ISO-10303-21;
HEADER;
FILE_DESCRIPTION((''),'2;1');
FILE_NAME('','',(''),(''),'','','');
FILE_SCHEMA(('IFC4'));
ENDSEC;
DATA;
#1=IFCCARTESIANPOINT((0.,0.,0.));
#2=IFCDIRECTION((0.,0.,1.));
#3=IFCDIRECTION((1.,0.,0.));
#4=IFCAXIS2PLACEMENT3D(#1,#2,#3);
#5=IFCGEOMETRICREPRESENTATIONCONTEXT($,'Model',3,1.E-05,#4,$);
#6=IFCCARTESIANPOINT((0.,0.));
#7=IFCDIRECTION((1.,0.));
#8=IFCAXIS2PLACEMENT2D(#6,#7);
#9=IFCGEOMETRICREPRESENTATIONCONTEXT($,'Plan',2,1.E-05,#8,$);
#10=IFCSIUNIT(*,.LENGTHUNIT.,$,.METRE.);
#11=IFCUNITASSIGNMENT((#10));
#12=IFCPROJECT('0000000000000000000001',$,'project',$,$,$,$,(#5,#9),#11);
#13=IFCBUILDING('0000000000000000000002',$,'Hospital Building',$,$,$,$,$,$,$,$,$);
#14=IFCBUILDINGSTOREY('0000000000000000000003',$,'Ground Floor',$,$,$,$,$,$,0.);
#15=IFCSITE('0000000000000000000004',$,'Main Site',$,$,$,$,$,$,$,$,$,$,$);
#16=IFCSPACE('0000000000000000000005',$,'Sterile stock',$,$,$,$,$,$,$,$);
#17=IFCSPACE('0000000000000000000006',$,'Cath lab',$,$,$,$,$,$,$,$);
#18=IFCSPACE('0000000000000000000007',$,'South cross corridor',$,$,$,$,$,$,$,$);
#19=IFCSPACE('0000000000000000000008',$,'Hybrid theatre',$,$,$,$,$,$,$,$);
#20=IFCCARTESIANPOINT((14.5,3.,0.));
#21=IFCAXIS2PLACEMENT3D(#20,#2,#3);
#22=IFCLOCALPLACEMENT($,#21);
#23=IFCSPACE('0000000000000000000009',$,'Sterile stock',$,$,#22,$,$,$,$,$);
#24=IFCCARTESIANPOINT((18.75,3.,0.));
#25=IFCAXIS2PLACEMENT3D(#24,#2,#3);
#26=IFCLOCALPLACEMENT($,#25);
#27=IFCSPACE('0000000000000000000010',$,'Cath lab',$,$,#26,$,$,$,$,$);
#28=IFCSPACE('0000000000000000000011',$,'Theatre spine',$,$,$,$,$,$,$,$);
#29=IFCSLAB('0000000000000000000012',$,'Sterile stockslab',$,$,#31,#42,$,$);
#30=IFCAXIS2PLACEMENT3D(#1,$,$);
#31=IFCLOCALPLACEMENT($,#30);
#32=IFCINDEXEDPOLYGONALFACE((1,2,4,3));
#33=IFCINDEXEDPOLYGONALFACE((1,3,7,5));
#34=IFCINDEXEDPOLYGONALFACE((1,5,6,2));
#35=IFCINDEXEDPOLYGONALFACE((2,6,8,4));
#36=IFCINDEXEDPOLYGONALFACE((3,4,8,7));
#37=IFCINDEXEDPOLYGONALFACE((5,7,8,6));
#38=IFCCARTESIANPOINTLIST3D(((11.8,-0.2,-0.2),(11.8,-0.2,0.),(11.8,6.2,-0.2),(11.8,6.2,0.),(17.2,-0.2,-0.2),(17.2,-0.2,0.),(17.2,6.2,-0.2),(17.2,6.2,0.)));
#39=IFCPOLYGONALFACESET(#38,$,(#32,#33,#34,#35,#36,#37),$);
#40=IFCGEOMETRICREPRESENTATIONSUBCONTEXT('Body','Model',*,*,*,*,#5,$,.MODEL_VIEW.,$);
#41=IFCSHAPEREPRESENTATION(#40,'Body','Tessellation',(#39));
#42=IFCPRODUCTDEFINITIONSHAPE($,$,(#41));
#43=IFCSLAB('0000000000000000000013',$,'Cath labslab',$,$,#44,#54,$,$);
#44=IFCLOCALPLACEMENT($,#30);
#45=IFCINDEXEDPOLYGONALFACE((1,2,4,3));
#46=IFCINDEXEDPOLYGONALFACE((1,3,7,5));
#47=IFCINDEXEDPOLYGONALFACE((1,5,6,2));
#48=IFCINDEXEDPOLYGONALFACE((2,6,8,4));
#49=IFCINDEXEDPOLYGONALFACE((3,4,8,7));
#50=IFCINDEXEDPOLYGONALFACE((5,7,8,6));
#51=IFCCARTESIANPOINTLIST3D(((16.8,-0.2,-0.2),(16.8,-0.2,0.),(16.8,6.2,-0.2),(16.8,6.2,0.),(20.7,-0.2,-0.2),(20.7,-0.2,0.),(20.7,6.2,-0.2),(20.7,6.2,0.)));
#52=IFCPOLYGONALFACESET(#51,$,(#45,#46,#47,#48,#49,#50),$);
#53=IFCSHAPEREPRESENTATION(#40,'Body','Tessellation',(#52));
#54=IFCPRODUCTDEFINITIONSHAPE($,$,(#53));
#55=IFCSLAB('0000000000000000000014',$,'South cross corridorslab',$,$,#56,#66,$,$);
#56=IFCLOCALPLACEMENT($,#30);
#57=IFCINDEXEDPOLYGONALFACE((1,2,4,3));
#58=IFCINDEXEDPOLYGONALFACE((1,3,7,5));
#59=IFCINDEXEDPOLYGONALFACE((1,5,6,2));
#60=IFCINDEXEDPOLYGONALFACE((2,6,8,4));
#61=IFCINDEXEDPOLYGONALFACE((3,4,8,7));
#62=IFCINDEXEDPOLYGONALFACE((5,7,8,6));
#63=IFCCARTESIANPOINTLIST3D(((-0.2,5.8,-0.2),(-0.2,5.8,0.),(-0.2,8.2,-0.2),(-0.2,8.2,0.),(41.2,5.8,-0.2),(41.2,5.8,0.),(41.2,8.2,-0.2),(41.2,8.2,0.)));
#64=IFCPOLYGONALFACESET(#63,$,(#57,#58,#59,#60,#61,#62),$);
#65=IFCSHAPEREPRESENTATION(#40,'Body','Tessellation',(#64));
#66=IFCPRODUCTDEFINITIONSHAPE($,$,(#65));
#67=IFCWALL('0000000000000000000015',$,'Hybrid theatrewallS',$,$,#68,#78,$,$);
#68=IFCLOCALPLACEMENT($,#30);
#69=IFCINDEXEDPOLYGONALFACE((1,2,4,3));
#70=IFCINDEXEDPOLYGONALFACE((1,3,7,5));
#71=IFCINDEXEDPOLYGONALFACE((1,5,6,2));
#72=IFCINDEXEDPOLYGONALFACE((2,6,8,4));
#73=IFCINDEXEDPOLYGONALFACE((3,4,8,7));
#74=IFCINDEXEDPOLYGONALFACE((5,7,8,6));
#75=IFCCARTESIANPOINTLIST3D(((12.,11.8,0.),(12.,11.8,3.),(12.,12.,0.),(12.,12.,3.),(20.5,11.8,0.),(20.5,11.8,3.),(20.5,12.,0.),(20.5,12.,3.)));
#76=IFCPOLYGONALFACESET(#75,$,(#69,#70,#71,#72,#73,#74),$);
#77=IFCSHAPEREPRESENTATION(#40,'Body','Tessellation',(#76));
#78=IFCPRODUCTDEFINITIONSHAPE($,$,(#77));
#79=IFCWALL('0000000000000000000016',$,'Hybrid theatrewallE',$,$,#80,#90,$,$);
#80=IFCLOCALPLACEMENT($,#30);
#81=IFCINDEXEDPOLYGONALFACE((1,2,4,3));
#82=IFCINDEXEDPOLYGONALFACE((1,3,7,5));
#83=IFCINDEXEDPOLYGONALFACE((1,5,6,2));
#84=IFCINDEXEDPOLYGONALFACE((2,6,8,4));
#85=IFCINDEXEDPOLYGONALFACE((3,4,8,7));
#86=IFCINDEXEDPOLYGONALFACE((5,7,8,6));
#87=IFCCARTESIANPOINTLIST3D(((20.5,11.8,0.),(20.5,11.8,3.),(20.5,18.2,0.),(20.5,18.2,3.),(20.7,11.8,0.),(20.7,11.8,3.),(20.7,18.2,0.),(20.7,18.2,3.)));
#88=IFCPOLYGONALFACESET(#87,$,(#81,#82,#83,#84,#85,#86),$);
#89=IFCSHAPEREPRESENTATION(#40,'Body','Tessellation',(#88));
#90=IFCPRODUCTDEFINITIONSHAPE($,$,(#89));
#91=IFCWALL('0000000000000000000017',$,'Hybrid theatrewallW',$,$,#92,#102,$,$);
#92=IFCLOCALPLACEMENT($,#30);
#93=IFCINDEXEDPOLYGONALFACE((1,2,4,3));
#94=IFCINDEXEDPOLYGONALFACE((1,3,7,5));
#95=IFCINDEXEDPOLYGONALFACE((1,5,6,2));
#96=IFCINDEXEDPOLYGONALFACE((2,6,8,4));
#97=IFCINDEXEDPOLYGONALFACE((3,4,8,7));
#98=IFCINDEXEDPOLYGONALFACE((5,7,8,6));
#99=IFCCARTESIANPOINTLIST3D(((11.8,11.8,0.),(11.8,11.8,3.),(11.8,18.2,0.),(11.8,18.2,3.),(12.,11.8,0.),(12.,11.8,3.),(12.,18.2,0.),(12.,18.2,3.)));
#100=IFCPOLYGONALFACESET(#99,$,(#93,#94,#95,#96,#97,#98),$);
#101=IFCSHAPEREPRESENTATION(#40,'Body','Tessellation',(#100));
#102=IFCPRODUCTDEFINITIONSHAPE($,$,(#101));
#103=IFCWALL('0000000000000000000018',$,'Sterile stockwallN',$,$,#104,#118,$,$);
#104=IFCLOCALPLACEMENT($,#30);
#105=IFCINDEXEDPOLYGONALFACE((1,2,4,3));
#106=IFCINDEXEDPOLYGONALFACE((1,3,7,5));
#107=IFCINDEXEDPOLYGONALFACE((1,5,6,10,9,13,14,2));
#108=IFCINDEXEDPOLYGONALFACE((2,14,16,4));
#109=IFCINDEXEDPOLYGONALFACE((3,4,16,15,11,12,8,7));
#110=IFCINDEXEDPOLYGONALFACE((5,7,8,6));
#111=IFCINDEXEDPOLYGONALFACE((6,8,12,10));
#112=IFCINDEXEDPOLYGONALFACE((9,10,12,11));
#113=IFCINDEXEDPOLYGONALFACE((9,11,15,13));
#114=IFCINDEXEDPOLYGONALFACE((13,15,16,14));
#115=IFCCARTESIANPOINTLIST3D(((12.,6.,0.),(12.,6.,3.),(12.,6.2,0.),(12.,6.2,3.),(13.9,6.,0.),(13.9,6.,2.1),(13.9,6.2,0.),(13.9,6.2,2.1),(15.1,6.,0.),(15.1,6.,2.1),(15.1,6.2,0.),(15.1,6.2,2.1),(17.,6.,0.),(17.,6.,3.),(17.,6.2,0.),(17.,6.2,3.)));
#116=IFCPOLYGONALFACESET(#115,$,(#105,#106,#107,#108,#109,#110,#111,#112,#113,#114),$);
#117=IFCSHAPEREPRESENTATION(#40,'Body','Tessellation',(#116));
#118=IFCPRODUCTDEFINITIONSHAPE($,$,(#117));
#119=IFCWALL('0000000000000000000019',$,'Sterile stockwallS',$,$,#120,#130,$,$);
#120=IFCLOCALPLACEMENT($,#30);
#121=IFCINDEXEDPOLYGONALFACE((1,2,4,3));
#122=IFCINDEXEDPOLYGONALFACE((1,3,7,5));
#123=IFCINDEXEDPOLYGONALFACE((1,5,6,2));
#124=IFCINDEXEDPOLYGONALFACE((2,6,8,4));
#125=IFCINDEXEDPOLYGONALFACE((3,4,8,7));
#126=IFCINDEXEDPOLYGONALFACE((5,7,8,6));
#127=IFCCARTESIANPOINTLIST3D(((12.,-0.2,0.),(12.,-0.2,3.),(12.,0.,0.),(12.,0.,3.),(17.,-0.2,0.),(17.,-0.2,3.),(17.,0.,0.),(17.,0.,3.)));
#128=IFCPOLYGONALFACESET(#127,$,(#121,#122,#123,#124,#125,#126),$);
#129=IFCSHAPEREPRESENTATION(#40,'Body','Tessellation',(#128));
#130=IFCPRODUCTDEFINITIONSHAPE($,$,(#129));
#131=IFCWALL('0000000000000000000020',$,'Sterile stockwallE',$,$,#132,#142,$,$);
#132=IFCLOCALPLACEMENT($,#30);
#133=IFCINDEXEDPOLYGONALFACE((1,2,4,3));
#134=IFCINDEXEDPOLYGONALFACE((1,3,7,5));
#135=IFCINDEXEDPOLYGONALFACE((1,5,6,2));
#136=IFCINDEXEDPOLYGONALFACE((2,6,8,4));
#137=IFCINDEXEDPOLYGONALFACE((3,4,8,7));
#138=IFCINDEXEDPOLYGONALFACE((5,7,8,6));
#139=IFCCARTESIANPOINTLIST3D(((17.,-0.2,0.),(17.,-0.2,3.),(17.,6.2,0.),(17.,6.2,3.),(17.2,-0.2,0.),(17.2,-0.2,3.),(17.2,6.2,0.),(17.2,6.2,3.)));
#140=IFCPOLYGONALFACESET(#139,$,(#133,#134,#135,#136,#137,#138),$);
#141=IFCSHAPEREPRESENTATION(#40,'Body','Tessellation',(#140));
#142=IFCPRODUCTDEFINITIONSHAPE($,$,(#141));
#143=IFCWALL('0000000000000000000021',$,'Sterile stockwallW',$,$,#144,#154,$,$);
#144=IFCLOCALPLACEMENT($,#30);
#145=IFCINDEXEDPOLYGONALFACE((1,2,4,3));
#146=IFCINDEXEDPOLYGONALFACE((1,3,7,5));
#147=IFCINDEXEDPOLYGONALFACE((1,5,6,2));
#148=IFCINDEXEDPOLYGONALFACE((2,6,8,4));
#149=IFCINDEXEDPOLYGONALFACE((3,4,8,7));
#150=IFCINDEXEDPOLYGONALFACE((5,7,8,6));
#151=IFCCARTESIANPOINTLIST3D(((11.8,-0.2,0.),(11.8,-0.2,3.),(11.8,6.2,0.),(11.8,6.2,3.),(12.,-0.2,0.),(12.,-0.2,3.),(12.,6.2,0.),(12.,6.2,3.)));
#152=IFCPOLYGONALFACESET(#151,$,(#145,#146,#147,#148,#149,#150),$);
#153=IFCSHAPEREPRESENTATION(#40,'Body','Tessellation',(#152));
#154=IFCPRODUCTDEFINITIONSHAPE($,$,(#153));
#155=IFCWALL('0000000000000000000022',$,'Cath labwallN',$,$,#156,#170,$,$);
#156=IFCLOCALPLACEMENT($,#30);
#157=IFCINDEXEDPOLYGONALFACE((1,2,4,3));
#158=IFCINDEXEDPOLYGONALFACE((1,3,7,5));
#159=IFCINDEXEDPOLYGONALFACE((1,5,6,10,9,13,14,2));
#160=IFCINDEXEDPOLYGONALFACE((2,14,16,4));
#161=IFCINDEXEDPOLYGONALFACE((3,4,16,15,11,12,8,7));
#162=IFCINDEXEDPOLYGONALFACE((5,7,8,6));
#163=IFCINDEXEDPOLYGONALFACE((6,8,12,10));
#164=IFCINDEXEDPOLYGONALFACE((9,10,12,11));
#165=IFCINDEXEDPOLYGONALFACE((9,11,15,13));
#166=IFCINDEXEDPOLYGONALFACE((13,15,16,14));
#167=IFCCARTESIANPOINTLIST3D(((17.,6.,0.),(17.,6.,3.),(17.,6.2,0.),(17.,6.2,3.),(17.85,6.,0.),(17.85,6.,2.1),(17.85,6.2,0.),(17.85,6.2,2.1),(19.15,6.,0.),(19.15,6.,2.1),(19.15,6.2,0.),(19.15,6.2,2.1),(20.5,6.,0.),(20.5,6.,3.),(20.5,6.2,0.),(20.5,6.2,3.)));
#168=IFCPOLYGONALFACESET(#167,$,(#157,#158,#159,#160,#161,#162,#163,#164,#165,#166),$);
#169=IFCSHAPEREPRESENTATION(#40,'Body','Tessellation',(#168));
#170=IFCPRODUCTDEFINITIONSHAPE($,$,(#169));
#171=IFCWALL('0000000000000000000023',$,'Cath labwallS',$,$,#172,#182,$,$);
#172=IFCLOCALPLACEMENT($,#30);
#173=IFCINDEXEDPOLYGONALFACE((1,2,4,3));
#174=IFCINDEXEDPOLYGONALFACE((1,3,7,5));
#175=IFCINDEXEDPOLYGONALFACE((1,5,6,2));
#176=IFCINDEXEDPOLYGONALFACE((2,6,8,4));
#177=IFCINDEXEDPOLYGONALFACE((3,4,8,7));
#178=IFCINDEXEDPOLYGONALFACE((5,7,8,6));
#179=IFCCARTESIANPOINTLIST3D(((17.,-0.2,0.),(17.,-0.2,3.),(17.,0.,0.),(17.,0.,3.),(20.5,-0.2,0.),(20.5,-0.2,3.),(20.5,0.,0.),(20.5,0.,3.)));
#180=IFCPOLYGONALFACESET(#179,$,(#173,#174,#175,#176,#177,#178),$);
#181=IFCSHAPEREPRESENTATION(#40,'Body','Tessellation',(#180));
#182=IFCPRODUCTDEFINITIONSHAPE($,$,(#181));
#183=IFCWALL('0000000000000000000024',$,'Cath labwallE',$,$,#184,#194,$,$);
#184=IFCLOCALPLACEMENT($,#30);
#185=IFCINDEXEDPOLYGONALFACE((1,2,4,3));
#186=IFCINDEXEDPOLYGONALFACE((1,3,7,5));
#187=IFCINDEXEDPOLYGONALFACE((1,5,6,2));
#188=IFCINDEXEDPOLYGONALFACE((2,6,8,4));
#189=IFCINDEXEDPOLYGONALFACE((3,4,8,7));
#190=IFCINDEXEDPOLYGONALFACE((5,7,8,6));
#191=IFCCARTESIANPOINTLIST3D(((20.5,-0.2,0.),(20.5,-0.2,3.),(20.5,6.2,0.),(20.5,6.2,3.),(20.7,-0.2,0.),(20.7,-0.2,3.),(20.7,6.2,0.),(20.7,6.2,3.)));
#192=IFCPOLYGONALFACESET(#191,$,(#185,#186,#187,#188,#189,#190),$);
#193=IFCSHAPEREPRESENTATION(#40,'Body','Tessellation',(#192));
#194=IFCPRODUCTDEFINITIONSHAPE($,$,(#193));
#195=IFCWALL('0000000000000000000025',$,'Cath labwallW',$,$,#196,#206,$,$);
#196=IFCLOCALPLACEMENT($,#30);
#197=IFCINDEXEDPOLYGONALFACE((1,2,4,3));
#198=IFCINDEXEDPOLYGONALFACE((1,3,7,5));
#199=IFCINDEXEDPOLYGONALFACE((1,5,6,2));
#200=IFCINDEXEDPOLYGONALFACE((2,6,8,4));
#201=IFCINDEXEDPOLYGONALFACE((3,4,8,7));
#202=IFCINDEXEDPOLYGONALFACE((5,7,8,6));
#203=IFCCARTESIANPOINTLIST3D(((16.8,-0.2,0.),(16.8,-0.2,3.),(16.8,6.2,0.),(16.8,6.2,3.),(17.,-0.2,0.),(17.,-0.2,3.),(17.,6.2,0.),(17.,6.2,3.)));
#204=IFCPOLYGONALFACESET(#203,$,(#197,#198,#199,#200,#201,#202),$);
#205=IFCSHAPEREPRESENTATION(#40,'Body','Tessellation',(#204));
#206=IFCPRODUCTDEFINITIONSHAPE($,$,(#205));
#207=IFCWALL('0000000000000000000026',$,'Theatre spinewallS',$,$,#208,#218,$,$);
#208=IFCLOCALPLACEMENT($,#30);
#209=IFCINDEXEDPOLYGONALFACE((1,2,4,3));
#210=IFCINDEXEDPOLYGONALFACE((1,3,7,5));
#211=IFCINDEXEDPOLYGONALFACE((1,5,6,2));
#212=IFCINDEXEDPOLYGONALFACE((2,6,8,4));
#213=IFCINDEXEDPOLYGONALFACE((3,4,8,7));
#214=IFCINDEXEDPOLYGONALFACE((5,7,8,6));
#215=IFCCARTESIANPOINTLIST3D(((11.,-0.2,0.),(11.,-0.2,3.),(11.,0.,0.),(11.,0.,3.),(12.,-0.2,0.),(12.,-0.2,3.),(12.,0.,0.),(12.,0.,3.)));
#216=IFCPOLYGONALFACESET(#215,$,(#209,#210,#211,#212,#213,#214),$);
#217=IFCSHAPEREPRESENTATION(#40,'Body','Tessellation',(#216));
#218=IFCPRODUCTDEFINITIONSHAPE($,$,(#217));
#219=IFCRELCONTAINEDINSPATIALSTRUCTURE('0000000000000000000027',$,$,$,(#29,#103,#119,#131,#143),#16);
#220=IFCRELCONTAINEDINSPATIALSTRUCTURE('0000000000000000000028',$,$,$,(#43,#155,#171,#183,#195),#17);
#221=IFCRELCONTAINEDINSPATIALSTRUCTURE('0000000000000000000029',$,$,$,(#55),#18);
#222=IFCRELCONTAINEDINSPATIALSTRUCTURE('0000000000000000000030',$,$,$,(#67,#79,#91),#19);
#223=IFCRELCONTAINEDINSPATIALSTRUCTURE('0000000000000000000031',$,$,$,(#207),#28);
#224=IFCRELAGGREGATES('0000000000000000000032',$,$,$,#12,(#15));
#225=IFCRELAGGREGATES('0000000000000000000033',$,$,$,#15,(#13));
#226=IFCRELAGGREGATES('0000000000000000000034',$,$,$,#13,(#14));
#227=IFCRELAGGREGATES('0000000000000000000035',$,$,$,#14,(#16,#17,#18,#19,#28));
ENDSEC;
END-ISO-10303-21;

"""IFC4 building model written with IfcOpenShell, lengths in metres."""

from ifc_helpers import new_model, si_unit, frame, origin_with_axes, origin_2d_with_axis, place, context, subcontext, project, spatial, indexed_curve, rectangle, outline, extrude, element, save


model = new_model("IFC4")

# Units and contexts
model_context = context("Model", 3, precision=1e-05, world=origin_with_axes())
plan_context = context("Plan", 2, precision=1e-05, world=origin_2d_with_axis())
body_context = subcontext(model_context, "Body", "Model", "MODEL_VIEW")
ifc_project = project(units=[si_unit("LENGTHUNIT", "METRE")], contexts=[model_context, plan_context])

# Site, building, storey, space
site = spatial("IfcSite", under=ifc_project, Name="Main Site")
building = spatial("IfcBuilding", under=site, Name="Hospital Building")
storey = spatial("IfcBuildingStorey", under=building, Name="Ground Floor", Elevation=0.0)
space_1 = spatial("IfcSpace", under=storey, Name="Sterile stock")

# Slab
slab_1_placement = place(None, frame((14.5, 3.0, -0.2), z_axis=(0.0, 0.0, 1.0), x_axis=(1.0, 0.0, 0.0)))
element("IfcSlab", 1, at=slab_1_placement, inside=space_1, Name="Sterile stockslab", context=body_context, shape_type="SweptSolid", body=[
    extrude(rectangle(XDim=5.4, YDim=6.4), origin_with_axes(), (0.0, 0.0, 1.0), 0.2),
])

# Shared definitions
space_2 = spatial("IfcSpace", under=storey, Name="Cath lab")

# Slab
slab_2_placement = place(None, frame((18.75, 3.0, -0.2), z_axis=(0.0, 0.0, 1.0), x_axis=(1.0, 0.0, 0.0)))
element("IfcSlab", 2, at=slab_2_placement, inside=space_2, Name="Cath labslab", context=body_context, shape_type="SweptSolid", body=[
    extrude(rectangle(XDim=3.9, YDim=6.4), origin_with_axes(), (0.0, 0.0, 1.0), 0.2),
])

# Shared definitions
space_3 = spatial("IfcSpace", under=storey, Name="South cross corridor")

# Slab
slab_3_placement = place(None, frame((20.5, 7.0, -0.2), z_axis=(0.0, 0.0, 1.0), x_axis=(1.0, 0.0, 0.0)))
element("IfcSlab", 3, at=slab_3_placement, inside=space_3, Name="South cross corridorslab", context=body_context, shape_type="SweptSolid", body=[
    extrude(rectangle(XDim=41.4, YDim=2.4), origin_with_axes(), (0.0, 0.0, 1.0), 0.2),
])

# Shared definitions
space_4 = spatial("IfcSpace", under=storey, Name="Hybrid theatre")

# Walls
wall_1_placement = place(None, frame((12.0, 11.8, 0.0), z_axis=(0.0, 0.0, 1.0), x_axis=(1.0, 0.0, 0.0)))
element("IfcWall", 4, at=wall_1_placement, inside=space_4, Name="Hybrid theatrewallS", context=body_context, shape_type="SweptSolid", body=[
    extrude(outline(indexed_curve([(0.0, 0.0), (0.0, 0.2), (8.5, 0.2), (8.5, 0.0), (0.0, 0.0)], self_intersect=False)), origin_with_axes(), (0.0, 0.0, 1.0), 3.0),
])
for number, where, z_axis, x_axis, name in (
    (5, (20.7, 11.8, 0.0), (0.0, 0.0, 1.0), (0.0, 1.0, 0.0), "Hybrid theatrewallE"),
    (6, (12.0, 11.8, 0.0), (0.0, 0.0, 1.0), (0.0, 1.0, 0.0), "Hybrid theatrewallW"),
):
    element("IfcWall", number, at=place(None, frame(where, z_axis=z_axis, x_axis=x_axis)), inside=space_4, Name=name, context=body_context, shape_type="SweptSolid", body=[
        extrude(outline(indexed_curve([(0.0, 0.0), (0.0, 0.2), (6.4, 0.2), (6.4, 0.0), (0.0, 0.0)], self_intersect=False)), origin_with_axes(), (0.0, 0.0, 1.0), 3.0),
    ])

# Wall
wall_2_placement = place(None, frame((12.0, 6.0, 0.0), z_axis=(0.0, 0.0, 1.0), x_axis=(1.0, 0.0, 0.0)))
wall_2 = element("IfcWall", 7, at=wall_2_placement, inside=space_1, Name="Sterile stockwallN", context=body_context, shape_type="SweptSolid", body=[
    extrude(outline(indexed_curve([(0.0, 0.0), (0.0, 0.2), (5.0, 0.2), (5.0, 0.0), (0.0, 0.0)], self_intersect=False)), origin_with_axes(), (0.0, 0.0, 1.0), 3.0),
])

# Shared definitions
space_5_placement = place(None, frame((14.5, 3.0, 0.0), z_axis=(0.0, 0.0, 1.0), x_axis=(1.0, 0.0, 0.0)))
space_5 = spatial("IfcSpace", at=space_5_placement, Name="Sterile stock")

# Opening
opening_1_placement = place(wall_2_placement, frame((1.9, -0.1, 0.0), z_axis=(0.0, 0.0, 1.0), x_axis=(1.0, 0.0, 0.0)))
element("IfcOpeningElement", 8, at=opening_1_placement, inside=space_5, cuts=wall_2, context=body_context, shape_type="SweptSolid", body=[
    extrude(outline(indexed_curve([(0.0, 0.0), (0.0, 0.4), (1.2, 0.4), (1.2, 0.0), (0.0, 0.0)], self_intersect=False)), origin_with_axes(), (0.0, 0.0, 1.0), 2.1),
])

# Walls
wall_3_placement = place(None, frame((12.0, -0.2, 0.0), z_axis=(0.0, 0.0, 1.0), x_axis=(1.0, 0.0, 0.0)))
element("IfcWall", 9, at=wall_3_placement, inside=space_1, Name="Sterile stockwallS", context=body_context, shape_type="SweptSolid", body=[
    extrude(outline(indexed_curve([(0.0, 0.0), (0.0, 0.2), (5.0, 0.2), (5.0, 0.0), (0.0, 0.0)], self_intersect=False)), origin_with_axes(), (0.0, 0.0, 1.0), 3.0),
])
for number, where, z_axis, x_axis, name in (
    (10, (17.2, -0.2, 0.0), (0.0, 0.0, 1.0), (0.0, 1.0, 0.0), "Sterile stockwallE"),
    (11, (12.0, -0.2, 0.0), (0.0, 0.0, 1.0), (0.0, 1.0, 0.0), "Sterile stockwallW"),
):
    element("IfcWall", number, at=place(None, frame(where, z_axis=z_axis, x_axis=x_axis)), inside=space_1, Name=name, context=body_context, shape_type="SweptSolid", body=[
        extrude(outline(indexed_curve([(0.0, 0.0), (0.0, 0.2), (6.4, 0.2), (6.4, 0.0), (0.0, 0.0)], self_intersect=False)), origin_with_axes(), (0.0, 0.0, 1.0), 3.0),
    ])

# Wall
wall_4_placement = place(None, frame((17.0, 6.0, 0.0), z_axis=(0.0, 0.0, 1.0), x_axis=(1.0, 0.0, 0.0)))
wall_4 = element("IfcWall", 12, at=wall_4_placement, inside=space_2, Name="Cath labwallN", context=body_context, shape_type="SweptSolid", body=[
    extrude(outline(indexed_curve([(0.0, 0.0), (0.0, 0.2), (3.5, 0.2), (3.5, 0.0), (0.0, 0.0)], self_intersect=False)), origin_with_axes(), (0.0, 0.0, 1.0), 3.0),
])

# Shared definitions
space_6_placement = place(None, frame((18.75, 3.0, 0.0), z_axis=(0.0, 0.0, 1.0), x_axis=(1.0, 0.0, 0.0)))
space_6 = spatial("IfcSpace", at=space_6_placement, Name="Cath lab")

# Opening
opening_2_placement = place(wall_4_placement, frame((0.85, -0.1, 0.0), z_axis=(0.0, 0.0, 1.0), x_axis=(1.0, 0.0, 0.0)))
element("IfcOpeningElement", 13, at=opening_2_placement, inside=space_6, cuts=wall_4, context=body_context, shape_type="SweptSolid", body=[
    extrude(outline(indexed_curve([(0.0, 0.0), (0.0, 0.4), (1.3, 0.4), (1.3, 0.0), (0.0, 0.0)], self_intersect=False)), origin_with_axes(), (0.0, 0.0, 1.0), 2.1),
])

# Walls
wall_5_placement = place(None, frame((17.0, -0.2, 0.0), z_axis=(0.0, 0.0, 1.0), x_axis=(1.0, 0.0, 0.0)))
element("IfcWall", 14, at=wall_5_placement, inside=space_2, Name="Cath labwallS", context=body_context, shape_type="SweptSolid", body=[
    extrude(outline(indexed_curve([(0.0, 0.0), (0.0, 0.2), (3.5, 0.2), (3.5, 0.0), (0.0, 0.0)], self_intersect=False)), origin_with_axes(), (0.0, 0.0, 1.0), 3.0),
])
for number, where, z_axis, x_axis, name in (
    (15, (20.7, -0.2, 0.0), (0.0, 0.0, 1.0), (0.0, 1.0, 0.0), "Cath labwallE"),
    (16, (17.0, -0.2, 0.0), (0.0, 0.0, 1.0), (0.0, 1.0, 0.0), "Cath labwallW"),
):
    element("IfcWall", number, at=place(None, frame(where, z_axis=z_axis, x_axis=x_axis)), inside=space_2, Name=name, context=body_context, shape_type="SweptSolid", body=[
        extrude(outline(indexed_curve([(0.0, 0.0), (0.0, 0.2), (6.4, 0.2), (6.4, 0.0), (0.0, 0.0)], self_intersect=False)), origin_with_axes(), (0.0, 0.0, 1.0), 3.0),
    ])

# Shared definitions
space_7 = spatial("IfcSpace", under=storey, Name="Theatre spine")

# Wall
wall_6_placement = place(None, frame((11.0, -0.2, 0.0), z_axis=(0.0, 0.0, 1.0), x_axis=(1.0, 0.0, 0.0)))
element("IfcWall", 17, at=wall_6_placement, inside=space_7, Name="Theatre spinewallS", context=body_context, shape_type="SweptSolid", body=[
    extrude(outline(indexed_curve([(0.0, 0.0), (0.0, 0.2), (1.0, 0.2), (1.0, 0.0), (0.0, 0.0)], self_intersect=False)), origin_with_axes(), (0.0, 0.0, 1.0), 3.0),
])

save(model, "model.ifc")
